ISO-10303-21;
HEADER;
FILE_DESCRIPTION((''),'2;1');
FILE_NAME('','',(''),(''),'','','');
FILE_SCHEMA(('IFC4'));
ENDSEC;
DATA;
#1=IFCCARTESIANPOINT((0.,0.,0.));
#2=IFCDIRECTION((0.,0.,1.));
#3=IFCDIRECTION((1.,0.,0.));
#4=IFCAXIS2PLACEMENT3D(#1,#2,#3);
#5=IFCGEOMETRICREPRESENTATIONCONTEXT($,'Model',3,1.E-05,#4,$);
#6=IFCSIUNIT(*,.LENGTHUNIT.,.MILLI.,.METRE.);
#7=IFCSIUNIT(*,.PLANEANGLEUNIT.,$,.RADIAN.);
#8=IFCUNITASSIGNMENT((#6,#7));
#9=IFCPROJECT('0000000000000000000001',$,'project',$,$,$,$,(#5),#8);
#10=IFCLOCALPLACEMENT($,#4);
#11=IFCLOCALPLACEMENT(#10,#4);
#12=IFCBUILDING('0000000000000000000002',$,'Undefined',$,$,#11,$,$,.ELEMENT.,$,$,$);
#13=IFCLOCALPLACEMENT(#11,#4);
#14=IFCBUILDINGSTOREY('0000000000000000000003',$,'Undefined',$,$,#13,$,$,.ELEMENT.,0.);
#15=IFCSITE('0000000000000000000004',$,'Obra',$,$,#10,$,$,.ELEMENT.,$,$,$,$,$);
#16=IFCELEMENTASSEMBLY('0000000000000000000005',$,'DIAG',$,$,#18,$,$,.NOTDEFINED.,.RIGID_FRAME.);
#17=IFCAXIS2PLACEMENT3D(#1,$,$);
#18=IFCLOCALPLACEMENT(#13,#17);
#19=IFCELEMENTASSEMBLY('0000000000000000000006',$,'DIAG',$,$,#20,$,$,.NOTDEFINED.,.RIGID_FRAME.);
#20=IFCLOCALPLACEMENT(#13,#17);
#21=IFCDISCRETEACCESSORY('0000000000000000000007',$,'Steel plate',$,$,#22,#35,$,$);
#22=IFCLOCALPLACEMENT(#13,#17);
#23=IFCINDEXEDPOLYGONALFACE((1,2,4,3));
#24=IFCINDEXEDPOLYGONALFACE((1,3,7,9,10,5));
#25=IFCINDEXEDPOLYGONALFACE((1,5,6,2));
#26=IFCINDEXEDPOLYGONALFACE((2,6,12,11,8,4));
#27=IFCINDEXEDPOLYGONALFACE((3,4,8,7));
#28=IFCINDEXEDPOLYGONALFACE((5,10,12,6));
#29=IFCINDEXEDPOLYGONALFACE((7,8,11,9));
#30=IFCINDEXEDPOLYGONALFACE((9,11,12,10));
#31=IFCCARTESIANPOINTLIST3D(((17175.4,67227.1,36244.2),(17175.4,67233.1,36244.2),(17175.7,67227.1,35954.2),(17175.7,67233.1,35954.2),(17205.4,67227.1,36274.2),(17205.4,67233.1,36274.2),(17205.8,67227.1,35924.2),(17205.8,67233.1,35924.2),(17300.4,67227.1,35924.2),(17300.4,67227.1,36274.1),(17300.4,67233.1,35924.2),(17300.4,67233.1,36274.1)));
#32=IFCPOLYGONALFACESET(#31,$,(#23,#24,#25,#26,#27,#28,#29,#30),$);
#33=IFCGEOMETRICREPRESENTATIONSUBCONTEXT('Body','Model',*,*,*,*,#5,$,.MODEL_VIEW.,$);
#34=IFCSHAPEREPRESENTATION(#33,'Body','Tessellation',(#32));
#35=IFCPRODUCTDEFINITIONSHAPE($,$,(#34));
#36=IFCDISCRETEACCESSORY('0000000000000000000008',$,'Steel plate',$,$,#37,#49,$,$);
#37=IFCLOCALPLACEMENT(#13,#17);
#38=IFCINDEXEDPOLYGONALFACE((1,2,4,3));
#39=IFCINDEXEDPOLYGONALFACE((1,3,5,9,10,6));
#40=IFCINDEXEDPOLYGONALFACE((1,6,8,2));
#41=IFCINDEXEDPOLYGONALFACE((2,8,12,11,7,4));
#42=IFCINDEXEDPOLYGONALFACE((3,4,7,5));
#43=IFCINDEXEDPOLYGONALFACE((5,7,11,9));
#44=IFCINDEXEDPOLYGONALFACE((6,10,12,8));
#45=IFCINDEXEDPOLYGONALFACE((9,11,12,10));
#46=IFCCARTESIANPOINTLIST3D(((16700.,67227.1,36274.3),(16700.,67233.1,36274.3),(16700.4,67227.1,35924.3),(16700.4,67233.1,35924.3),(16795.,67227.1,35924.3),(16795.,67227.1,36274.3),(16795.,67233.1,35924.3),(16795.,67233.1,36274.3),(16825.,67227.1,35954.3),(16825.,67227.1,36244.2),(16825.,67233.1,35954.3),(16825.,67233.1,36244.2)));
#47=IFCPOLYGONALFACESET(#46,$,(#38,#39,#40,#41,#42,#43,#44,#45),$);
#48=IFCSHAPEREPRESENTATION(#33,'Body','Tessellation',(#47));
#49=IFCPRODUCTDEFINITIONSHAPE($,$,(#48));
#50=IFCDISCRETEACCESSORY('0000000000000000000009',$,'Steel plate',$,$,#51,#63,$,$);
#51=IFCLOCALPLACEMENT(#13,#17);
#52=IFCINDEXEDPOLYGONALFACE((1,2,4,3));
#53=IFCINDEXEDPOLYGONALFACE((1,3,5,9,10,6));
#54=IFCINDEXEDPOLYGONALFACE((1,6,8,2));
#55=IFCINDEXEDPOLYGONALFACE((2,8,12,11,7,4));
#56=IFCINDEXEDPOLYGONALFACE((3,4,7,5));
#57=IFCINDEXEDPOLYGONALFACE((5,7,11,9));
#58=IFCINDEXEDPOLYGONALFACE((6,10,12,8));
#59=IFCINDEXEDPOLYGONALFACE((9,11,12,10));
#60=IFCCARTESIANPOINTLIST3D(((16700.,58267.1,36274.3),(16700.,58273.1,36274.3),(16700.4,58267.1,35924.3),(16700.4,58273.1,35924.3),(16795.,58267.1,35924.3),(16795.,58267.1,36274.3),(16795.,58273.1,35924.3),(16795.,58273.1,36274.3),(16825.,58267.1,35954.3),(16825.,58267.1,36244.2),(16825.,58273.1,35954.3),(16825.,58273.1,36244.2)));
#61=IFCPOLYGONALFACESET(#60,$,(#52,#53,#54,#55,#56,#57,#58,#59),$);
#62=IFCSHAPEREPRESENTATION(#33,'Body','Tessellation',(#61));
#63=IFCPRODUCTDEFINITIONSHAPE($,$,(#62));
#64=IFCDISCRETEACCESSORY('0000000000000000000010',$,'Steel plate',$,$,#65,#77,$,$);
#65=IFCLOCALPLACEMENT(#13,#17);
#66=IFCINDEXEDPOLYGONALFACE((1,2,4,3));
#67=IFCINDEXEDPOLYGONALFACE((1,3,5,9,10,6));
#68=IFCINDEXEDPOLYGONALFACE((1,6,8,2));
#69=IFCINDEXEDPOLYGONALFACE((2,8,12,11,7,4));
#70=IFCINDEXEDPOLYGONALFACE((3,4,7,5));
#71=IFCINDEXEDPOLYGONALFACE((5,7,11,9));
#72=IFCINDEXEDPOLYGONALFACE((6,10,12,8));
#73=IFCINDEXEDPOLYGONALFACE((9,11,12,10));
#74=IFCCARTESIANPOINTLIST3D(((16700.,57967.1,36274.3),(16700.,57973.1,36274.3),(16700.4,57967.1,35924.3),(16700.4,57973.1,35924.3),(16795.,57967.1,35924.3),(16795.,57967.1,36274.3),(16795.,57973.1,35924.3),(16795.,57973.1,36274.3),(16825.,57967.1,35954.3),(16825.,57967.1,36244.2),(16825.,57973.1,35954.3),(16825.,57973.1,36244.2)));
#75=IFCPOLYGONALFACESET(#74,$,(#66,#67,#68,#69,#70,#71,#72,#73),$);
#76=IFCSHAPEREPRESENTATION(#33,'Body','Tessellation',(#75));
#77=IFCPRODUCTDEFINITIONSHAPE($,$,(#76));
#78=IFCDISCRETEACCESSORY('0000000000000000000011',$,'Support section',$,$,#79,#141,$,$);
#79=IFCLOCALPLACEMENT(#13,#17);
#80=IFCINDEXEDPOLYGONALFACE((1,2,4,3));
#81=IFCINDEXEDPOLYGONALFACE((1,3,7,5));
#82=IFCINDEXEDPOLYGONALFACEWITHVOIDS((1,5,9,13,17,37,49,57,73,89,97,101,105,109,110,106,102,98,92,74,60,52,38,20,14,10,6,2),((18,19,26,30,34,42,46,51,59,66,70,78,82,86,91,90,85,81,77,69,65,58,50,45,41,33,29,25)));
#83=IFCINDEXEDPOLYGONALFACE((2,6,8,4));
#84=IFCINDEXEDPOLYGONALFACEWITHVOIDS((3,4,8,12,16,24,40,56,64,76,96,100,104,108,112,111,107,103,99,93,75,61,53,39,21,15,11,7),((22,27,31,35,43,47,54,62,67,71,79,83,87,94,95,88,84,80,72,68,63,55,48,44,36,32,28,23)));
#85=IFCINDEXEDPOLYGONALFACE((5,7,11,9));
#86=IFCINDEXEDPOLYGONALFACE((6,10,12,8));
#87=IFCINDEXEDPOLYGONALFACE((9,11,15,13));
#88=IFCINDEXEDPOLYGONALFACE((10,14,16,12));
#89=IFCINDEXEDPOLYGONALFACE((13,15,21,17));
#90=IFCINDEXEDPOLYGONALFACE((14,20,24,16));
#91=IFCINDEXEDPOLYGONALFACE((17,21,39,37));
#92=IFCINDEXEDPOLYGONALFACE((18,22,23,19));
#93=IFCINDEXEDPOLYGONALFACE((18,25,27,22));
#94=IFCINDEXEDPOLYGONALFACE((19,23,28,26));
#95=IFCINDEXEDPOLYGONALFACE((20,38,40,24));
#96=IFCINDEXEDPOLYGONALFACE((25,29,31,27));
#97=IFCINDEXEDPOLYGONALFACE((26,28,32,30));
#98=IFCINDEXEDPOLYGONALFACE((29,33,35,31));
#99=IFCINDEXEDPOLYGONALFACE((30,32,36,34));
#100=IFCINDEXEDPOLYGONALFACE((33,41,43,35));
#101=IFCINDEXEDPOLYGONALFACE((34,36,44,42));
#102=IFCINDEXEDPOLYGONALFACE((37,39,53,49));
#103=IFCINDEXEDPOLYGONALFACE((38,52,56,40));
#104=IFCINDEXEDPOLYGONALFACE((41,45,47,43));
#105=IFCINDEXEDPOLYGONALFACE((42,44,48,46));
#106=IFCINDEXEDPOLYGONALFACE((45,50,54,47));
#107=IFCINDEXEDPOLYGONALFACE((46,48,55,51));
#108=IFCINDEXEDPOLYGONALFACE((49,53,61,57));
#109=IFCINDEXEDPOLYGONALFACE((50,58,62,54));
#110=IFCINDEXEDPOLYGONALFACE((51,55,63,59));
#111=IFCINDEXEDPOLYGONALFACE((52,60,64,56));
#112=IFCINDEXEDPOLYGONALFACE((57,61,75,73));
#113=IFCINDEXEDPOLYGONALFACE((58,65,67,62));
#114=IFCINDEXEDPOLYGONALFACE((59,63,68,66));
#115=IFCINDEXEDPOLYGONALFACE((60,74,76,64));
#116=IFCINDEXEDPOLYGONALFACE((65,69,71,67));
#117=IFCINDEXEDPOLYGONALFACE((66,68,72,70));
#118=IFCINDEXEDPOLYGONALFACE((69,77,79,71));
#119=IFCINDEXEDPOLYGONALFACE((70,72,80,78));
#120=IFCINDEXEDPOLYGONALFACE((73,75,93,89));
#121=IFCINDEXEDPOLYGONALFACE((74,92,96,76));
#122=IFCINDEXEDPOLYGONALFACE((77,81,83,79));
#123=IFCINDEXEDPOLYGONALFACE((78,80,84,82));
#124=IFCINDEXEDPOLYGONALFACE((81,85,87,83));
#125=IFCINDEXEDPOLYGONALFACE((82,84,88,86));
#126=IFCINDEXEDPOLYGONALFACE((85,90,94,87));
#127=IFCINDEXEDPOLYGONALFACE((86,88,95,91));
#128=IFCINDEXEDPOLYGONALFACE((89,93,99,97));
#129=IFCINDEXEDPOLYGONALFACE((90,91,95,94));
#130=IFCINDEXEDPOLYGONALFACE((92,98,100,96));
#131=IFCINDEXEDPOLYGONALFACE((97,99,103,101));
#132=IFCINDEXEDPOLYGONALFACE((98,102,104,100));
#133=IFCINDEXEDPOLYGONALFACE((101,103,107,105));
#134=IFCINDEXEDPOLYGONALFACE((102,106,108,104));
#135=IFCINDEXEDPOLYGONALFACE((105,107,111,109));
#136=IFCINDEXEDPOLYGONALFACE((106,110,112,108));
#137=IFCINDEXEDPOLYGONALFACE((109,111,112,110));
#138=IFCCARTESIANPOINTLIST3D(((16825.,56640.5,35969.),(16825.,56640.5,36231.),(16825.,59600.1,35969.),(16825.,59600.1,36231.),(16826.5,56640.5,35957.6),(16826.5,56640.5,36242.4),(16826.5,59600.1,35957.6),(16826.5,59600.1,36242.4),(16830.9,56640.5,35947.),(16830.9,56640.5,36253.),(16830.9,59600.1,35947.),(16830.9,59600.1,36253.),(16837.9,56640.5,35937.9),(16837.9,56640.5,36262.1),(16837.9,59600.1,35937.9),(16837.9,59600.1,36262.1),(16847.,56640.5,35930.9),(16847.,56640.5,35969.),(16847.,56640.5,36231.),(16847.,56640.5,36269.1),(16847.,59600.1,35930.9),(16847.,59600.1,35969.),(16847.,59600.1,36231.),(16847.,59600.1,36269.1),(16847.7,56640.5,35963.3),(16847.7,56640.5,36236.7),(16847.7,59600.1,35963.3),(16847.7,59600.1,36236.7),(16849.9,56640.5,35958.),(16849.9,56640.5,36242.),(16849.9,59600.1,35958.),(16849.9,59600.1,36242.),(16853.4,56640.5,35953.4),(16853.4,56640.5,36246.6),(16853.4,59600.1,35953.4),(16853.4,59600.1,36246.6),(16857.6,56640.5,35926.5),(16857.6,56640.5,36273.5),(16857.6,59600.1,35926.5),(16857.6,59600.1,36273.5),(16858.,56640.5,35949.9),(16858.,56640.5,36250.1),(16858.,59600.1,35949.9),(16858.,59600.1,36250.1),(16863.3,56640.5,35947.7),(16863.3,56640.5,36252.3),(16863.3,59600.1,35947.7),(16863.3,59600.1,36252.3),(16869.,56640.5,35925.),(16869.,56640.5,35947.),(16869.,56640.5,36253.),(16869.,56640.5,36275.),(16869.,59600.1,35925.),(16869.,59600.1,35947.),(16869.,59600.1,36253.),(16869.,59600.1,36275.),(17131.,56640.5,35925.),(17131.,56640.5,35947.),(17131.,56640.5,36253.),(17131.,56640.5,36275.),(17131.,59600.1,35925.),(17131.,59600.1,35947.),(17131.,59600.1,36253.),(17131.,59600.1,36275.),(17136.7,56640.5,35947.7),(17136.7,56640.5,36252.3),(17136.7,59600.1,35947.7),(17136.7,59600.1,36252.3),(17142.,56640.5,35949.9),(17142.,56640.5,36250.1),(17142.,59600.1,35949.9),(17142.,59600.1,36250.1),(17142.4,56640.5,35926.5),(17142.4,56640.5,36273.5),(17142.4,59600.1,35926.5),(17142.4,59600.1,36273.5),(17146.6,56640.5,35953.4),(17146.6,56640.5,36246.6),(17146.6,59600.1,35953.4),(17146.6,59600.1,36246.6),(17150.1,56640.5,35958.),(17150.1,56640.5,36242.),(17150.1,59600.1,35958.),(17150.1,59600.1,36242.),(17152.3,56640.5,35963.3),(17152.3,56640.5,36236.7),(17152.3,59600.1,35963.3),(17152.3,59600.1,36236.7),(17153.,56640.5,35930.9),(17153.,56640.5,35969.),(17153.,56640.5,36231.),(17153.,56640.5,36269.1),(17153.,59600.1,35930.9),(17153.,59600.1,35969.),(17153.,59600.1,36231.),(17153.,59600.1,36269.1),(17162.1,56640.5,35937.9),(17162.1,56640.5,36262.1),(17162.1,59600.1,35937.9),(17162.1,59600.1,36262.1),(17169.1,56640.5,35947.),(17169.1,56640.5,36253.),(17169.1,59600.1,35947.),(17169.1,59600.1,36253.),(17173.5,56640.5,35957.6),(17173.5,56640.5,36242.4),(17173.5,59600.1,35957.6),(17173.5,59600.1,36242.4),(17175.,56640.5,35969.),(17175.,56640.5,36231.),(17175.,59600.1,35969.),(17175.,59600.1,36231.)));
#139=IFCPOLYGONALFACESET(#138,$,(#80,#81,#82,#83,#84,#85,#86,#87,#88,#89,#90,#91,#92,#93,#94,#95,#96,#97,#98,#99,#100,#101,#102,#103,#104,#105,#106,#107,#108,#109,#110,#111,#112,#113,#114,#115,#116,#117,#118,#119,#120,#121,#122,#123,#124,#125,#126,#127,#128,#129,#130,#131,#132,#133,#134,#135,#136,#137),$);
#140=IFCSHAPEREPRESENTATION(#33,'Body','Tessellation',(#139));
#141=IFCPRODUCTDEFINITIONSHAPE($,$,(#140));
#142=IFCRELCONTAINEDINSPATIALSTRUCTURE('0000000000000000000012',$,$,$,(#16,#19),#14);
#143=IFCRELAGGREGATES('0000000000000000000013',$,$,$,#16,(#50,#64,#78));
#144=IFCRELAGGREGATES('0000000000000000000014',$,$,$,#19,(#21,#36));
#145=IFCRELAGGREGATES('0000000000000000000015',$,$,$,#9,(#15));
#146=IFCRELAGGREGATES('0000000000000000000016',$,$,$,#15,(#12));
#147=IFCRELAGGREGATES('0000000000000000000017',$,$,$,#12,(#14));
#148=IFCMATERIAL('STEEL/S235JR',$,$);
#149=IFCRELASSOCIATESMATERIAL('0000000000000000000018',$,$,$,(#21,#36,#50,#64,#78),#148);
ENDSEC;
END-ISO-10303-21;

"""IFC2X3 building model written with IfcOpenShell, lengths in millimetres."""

from ifc_helpers import new_model, si_unit, frame, origin_with_axes, origin_2d_with_axis, place, context, subcontext, project, spatial, polyline, hollow_rectangle, outline, extrude, clip, halfspace, material, element, aggregate, save


model = new_model("IFC2X3")

# Units and contexts
model_context = context("Model", 3, precision=1e-05, world=origin_with_axes())
body_context = subcontext(model_context, "Body", "Model", "MODEL_VIEW")
ifc_project = project(units=[si_unit("LENGTHUNIT", "METRE", prefix="MILLI"), si_unit("PLANEANGLEUNIT", "RADIAN")], contexts=[model_context])

# Site, building, storey
site_placement = place(None, origin_with_axes())
site = spatial("IfcSite", under=ifc_project, at=site_placement, Name="Obra", CompositionType="ELEMENT")
building_placement = place(site_placement, origin_with_axes())
building = spatial("IfcBuilding", under=site, at=building_placement, Name="Undefined", CompositionType="ELEMENT")
storey_placement = place(building_placement, origin_with_axes())
storey = spatial("IfcBuildingStorey", under=building, at=storey_placement, Name="Undefined", CompositionType="ELEMENT", Elevation=0.0)

# Element assemblies
assembly_1_placement = place(storey_placement, origin_with_axes())
assembly_1 = element("IfcElementAssembly", 1, at=assembly_1_placement, inside=storey, Name="DIAG", AssemblyPlace="NOTDEFINED", PredefinedType="RIGID_FRAME")
ifc_material_1 = material(Name="STEEL/S235JR")
assembly_2_placement = place(storey_placement, origin_with_axes())
assembly_2 = element("IfcElementAssembly", 2, at=assembly_2_placement, inside=storey, Name="DIAG", AssemblyPlace="NOTDEFINED", PredefinedType="RIGID_FRAME")

# Discrete accessories
discrete_accessory_1_placement = place(assembly_2_placement, frame((17300.4, 67230.1, 35924.2), z_axis=(0.0, 1.0, 0.0), x_axis=(-1.0, 0.0, 0.0)))
discrete_accessory_1 = element("IfcDiscreteAccessory", 3, at=discrete_accessory_1_placement, material=ifc_material_1, Name="Steel plate", context=body_context, shape_type="SweptSolid", body=[
    extrude(outline(polyline([(0.0, 0.0), (94.6, 0.0), (124.6, 30.0), (125.0, 320.0), (95.0, 350.0), (0.0, 349.9), (0.0, 0.0)])), frame((0.0, 0.0, -3.0), z_axis=(0.0, 0.0, 1.0), x_axis=(1.0, 0.0, 0.0)), (0.0, 0.0, 1.0), 6.0),
])
discrete_accessory_2_placement = place(assembly_2_placement, frame((16825.0, 67230.1, 35924.3), z_axis=(0.0, 1.0, 0.0), x_axis=(-1.0, 0.0, 0.0)))
discrete_accessory_2 = element("IfcDiscreteAccessory", 4, at=discrete_accessory_2_placement, material=ifc_material_1, Name="Steel plate", context=body_context, shape_type="SweptSolid", body=[
    extrude(outline(polyline([(0.0, 30.0), (30.0, 0.0), (124.6, 0.0), (125.0, 350.0), (30.0, 349.9), (0.0, 319.9), (0.0, 30.0)])), frame((0.0, 0.0, -3.0), z_axis=(0.0, 0.0, 1.0), x_axis=(1.0, 0.0, 0.0)), (0.0, 0.0, 1.0), 6.0),
])
discrete_accessory_3_placement = place(assembly_1_placement, frame((16825.0, 58270.1, 35924.3), z_axis=(0.0, 1.0, 0.0), x_axis=(-1.0, 0.0, 0.0)))
discrete_accessory_3 = element("IfcDiscreteAccessory", 5, at=discrete_accessory_3_placement, material=ifc_material_1, Name="Steel plate", context=body_context, shape_type="SweptSolid", body=[
    extrude(outline(polyline([(0.0, 30.0), (30.0, 0.0), (124.6, 0.0), (125.0, 350.0), (30.0, 349.9), (0.0, 319.9), (0.0, 30.0)])), frame((0.0, 0.0, -3.0), z_axis=(0.0, 0.0, 1.0), x_axis=(1.0, 0.0, 0.0)), (0.0, 0.0, 1.0), 6.0),
])
discrete_accessory_4_placement = place(assembly_1_placement, frame((16825.0, 57970.1, 35924.3), z_axis=(0.0, 1.0, 0.0), x_axis=(-1.0, 0.0, 0.0)))
discrete_accessory_4 = element("IfcDiscreteAccessory", 6, at=discrete_accessory_4_placement, material=ifc_material_1, Name="Steel plate", context=body_context, shape_type="SweptSolid", body=[
    extrude(outline(polyline([(0.0, 30.0), (30.0, 0.0), (124.6, 0.0), (125.0, 350.0), (30.0, 349.9), (0.0, 319.9), (0.0, 30.0)])), frame((0.0, 0.0, -3.0), z_axis=(0.0, 0.0, 1.0), x_axis=(1.0, 0.0, 0.0)), (0.0, 0.0, 1.0), 6.0),
])

# Discrete accessory
discrete_accessory_5_placement = place(assembly_1_placement, frame((17000.0, 56620.1, 36100.0), z_axis=(0.0, 0.0, 1.0), x_axis=(0.0, 1.0, 0.0)))
discrete_accessory_5 = element("IfcDiscreteAccessory", 7, at=discrete_accessory_5_placement, material=ifc_material_1, Name="Support section", context=body_context, shape_type="Clipping", body=[
    clip(clip(extrude(hollow_rectangle(XDim=350.0, YDim=350.0, WallThickness=22.0, InnerFilletRadius=22.0, OuterFilletRadius=44.0, at=origin_2d_with_axis()), frame((2980.0, 0.0, 0.0), z_axis=(-1.0, 0.0, 0.0), x_axis=(0.0, -1.0, 0.0)), (0.0, 0.0, 1.0), 2959.6), halfspace(frame((2979.9, 0.0, -1000.0), z_axis=(-1.0, 0.0, 0.000056), x_axis=(0.0, 1.0, 0.0)), True)), halfspace(frame((20.4, 0.0, -175.0), z_axis=(1.0, 0.0, -0.000038), x_axis=(0.0, -1.0, 0.0)), True)),
])
aggregate(assembly_1, [discrete_accessory_3, discrete_accessory_4, discrete_accessory_5])
aggregate(assembly_2, [discrete_accessory_1, discrete_accessory_2])

save(model, "model.ifc")
